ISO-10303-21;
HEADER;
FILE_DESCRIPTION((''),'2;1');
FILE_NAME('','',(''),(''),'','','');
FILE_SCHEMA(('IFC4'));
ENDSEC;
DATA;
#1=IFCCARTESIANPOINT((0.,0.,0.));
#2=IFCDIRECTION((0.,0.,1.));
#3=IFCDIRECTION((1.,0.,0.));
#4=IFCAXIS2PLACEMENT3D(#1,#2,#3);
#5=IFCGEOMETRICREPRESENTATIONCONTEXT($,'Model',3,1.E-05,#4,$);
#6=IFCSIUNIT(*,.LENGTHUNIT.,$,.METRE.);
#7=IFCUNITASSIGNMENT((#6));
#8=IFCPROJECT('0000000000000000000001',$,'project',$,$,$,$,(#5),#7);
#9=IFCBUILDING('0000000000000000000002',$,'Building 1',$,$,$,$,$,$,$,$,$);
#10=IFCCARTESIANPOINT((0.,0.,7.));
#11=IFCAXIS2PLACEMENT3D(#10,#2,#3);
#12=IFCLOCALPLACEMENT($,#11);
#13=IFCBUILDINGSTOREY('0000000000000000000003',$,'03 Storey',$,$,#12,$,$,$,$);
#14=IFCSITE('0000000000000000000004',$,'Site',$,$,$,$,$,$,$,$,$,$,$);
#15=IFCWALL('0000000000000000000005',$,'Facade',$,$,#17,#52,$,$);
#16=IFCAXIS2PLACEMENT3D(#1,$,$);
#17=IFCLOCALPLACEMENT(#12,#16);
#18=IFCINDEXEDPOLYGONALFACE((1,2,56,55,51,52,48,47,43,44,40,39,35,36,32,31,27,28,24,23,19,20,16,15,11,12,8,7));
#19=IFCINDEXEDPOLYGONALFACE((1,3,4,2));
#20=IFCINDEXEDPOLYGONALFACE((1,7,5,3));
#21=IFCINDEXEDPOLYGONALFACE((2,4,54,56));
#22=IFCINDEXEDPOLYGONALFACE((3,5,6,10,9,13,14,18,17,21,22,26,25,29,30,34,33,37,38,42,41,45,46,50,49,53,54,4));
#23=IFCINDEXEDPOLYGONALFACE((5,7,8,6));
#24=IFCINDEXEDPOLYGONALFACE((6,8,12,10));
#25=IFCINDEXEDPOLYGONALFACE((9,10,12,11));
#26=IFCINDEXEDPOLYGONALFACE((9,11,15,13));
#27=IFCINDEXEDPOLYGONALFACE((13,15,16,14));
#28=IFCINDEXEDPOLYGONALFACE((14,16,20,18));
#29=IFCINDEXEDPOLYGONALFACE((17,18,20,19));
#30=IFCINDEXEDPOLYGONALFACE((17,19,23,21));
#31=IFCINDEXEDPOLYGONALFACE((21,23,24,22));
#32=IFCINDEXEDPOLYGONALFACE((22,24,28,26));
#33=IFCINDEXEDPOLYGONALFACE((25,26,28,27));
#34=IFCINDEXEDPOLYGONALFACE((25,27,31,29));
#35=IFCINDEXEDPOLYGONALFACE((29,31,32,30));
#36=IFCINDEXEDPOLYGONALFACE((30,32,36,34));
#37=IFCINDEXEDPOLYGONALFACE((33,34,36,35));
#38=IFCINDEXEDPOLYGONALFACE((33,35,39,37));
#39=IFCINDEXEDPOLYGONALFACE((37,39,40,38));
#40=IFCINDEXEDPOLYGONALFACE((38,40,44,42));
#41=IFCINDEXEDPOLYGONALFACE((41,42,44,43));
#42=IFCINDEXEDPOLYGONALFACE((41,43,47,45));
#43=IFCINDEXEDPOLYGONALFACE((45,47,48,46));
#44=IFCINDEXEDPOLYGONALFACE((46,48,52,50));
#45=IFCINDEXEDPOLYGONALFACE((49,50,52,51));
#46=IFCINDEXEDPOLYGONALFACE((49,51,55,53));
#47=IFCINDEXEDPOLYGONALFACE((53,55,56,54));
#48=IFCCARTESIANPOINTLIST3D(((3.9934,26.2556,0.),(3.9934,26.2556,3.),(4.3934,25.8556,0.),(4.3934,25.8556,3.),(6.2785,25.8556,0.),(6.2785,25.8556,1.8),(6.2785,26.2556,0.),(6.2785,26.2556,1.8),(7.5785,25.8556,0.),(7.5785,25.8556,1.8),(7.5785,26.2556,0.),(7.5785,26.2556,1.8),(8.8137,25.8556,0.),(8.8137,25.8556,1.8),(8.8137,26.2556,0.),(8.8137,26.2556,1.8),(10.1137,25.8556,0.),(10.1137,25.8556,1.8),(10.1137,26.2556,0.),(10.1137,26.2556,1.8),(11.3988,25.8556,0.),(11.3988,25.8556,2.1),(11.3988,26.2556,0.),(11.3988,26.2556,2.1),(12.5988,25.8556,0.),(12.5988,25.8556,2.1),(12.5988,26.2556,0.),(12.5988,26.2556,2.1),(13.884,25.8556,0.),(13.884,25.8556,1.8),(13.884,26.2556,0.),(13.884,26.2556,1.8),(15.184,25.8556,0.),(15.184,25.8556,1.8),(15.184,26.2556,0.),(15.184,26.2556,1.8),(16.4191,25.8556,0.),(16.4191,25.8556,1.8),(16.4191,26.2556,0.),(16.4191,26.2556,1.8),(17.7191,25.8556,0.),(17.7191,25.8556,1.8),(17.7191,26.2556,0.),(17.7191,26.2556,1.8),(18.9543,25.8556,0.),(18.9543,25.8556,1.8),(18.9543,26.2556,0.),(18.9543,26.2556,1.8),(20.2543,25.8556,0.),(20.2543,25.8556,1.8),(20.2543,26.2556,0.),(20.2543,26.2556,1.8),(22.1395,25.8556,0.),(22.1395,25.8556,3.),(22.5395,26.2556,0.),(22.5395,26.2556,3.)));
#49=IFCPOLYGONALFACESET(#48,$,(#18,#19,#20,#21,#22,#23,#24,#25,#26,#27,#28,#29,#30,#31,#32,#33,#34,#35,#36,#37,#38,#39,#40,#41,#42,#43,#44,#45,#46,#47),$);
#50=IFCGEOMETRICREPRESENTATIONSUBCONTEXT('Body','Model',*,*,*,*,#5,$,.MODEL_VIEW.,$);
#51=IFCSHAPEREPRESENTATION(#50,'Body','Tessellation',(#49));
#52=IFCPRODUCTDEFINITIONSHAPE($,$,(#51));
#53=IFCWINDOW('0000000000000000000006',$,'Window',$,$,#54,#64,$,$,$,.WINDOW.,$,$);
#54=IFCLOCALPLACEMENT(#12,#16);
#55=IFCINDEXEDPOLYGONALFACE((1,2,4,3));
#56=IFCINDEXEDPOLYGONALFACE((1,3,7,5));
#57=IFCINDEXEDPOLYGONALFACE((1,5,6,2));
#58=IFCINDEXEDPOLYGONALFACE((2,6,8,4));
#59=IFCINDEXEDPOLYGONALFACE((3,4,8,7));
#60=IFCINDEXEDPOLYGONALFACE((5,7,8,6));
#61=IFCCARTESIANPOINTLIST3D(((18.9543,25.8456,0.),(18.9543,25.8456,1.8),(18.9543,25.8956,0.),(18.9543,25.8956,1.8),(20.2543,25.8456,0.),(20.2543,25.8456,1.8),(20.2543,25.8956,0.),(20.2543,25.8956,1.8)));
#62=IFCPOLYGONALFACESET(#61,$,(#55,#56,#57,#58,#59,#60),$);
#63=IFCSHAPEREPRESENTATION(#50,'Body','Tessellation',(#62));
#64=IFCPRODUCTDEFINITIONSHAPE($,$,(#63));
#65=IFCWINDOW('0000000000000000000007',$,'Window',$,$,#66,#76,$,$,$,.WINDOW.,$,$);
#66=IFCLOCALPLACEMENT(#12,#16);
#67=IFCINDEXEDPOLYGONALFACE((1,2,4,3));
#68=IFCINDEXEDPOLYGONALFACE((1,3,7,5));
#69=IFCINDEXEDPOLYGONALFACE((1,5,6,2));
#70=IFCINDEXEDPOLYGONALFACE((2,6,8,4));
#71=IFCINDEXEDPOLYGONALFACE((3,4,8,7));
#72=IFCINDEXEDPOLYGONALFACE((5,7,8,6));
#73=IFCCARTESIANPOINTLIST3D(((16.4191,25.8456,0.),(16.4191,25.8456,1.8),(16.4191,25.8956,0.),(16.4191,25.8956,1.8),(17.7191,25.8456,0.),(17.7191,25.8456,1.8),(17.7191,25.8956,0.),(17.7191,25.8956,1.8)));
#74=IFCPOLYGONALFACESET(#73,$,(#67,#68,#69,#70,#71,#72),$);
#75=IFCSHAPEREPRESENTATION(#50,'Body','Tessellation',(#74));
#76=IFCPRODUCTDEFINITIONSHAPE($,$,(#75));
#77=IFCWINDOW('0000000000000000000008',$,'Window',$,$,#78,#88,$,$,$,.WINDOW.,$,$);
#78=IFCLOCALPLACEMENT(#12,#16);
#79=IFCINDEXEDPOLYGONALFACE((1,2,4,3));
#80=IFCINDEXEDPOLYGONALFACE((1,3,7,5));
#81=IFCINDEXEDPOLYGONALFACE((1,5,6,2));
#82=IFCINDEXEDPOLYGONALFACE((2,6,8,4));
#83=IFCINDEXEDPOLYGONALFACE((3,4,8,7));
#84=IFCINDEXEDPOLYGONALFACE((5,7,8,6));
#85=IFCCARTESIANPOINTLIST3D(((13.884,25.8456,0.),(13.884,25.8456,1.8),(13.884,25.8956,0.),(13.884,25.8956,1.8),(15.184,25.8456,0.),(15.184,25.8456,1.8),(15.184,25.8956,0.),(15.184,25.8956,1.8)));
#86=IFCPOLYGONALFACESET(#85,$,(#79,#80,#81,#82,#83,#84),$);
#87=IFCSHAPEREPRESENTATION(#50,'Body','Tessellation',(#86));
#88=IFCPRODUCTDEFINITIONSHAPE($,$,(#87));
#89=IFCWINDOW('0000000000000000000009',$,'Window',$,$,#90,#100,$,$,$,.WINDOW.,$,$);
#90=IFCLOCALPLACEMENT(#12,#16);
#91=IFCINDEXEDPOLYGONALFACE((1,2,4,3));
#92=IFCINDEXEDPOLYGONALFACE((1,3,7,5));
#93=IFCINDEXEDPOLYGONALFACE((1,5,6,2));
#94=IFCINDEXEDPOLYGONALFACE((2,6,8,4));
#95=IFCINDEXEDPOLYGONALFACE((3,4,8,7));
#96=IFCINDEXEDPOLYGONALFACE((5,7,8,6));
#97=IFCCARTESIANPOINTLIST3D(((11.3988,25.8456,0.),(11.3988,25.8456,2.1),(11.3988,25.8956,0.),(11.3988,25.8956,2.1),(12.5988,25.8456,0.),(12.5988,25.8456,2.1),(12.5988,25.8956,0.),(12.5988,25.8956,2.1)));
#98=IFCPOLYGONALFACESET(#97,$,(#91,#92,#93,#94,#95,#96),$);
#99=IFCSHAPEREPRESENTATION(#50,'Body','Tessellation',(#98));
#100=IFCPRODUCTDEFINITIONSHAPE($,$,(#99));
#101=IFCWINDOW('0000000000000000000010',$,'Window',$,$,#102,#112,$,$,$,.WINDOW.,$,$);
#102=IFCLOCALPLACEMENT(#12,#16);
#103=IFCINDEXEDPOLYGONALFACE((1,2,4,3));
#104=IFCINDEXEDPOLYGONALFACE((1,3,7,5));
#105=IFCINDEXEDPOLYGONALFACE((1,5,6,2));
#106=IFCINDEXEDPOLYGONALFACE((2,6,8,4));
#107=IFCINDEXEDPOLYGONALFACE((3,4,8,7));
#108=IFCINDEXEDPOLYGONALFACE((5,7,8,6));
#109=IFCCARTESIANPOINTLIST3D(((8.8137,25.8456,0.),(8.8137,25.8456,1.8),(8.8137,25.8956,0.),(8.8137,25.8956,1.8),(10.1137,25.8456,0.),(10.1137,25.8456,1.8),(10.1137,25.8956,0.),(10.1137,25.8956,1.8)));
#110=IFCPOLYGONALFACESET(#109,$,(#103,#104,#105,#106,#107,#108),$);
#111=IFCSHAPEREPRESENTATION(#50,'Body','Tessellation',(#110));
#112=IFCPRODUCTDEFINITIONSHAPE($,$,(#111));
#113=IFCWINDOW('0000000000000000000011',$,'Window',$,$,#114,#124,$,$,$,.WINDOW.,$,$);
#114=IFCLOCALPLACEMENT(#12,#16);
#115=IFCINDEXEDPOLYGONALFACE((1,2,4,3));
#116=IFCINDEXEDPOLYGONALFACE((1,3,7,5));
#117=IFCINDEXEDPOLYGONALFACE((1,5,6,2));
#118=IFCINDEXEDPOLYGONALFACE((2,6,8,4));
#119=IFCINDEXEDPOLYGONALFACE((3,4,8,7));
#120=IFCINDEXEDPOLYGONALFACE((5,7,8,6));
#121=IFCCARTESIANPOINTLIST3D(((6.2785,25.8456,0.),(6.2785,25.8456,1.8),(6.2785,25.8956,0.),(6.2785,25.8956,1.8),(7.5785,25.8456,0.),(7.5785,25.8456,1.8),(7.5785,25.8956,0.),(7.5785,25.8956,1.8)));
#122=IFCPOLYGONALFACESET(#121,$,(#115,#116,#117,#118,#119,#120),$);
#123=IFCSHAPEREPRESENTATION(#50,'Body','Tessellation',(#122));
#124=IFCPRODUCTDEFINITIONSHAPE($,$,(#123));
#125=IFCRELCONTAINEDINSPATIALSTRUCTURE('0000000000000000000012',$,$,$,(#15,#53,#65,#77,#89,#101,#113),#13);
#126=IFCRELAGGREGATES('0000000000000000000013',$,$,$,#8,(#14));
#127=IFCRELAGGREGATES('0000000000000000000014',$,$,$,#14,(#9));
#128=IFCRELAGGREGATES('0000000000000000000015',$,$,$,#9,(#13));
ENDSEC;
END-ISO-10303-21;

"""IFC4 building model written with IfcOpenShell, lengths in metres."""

from ifc_helpers import new_model, si_unit, frame, origin_with_axes, place, context, subcontext, project, spatial, line, indexed_curve, outline, extrude, element, fill, save


model = new_model("IFC4")

# Units and contexts
model_context = context("Model", 3, precision=1e-05, world=origin_with_axes())
body_context = subcontext(model_context, "Body", "Model", "MODEL_VIEW")
ifc_project = project(units=[si_unit("LENGTHUNIT", "METRE")], contexts=[model_context])

# Site, building, storey
site = spatial("IfcSite", under=ifc_project, Name="Site")
building = spatial("IfcBuilding", under=site, Name="Building 1")
storey_placement = place(None, frame((0.0, 0.0, 7.0), z_axis=(0.0, 0.0, 1.0), x_axis=(1.0, 0.0, 0.0)))
storey = spatial("IfcBuildingStorey", under=building, at=storey_placement, Name="03 Storey")

# Wall, openings, windows
wall_1_placement = place(storey_placement, origin_with_axes())
wall_1 = element("IfcWall", 1, at=wall_1_placement, inside=storey, Name="Facade", context=body_context, shape_type="SweptSolid", body=[
    extrude(outline(indexed_curve([(22.1395, 25.8556), (4.3934, 25.8556), (3.9934, 26.2556), (22.5395, 26.2556)], segments=[line(1, 2), line(2, 3), line(3, 4)])), origin_with_axes(), (0.0, 0.0, 1.0), 3.0),
])
opening_1_placement = place(wall_1_placement, origin_with_axes())
opening_1 = element("IfcOpeningElement", 2, at=opening_1_placement, cuts=wall_1, context=body_context, shape_type="SweptSolid", body=[
    extrude(outline(indexed_curve([(20.2543, 26.2956), (20.2543, 25.7956), (18.9543, 25.7956), (18.9543, 26.2956)], segments=[line(1, 2), line(2, 3), line(3, 4)])), origin_with_axes(), (0.0, 0.0, 1.0), 1.8),
])
opening_2_placement = place(wall_1_placement, origin_with_axes())
opening_2 = element("IfcOpeningElement", 3, at=opening_2_placement, cuts=wall_1, context=body_context, shape_type="SweptSolid", body=[
    extrude(outline(indexed_curve([(17.7191, 26.2956), (17.7191, 25.7956), (16.4191, 25.7956), (16.4191, 26.2956)], segments=[line(1, 2), line(2, 3), line(3, 4)])), origin_with_axes(), (0.0, 0.0, 1.0), 1.8),
])
opening_3_placement = place(wall_1_placement, origin_with_axes())
opening_3 = element("IfcOpeningElement", 4, at=opening_3_placement, cuts=wall_1, context=body_context, shape_type="SweptSolid", body=[
    extrude(outline(indexed_curve([(15.184, 26.2956), (15.184, 25.7956), (13.884, 25.7956), (13.884, 26.2956)], segments=[line(1, 2), line(2, 3), line(3, 4)])), origin_with_axes(), (0.0, 0.0, 1.0), 1.8),
])
opening_4_placement = place(wall_1_placement, origin_with_axes())
opening_4 = element("IfcOpeningElement", 5, at=opening_4_placement, cuts=wall_1, context=body_context, shape_type="SweptSolid", body=[
    extrude(outline(indexed_curve([(12.5988, 26.2956), (12.5988, 25.7956), (11.3988, 25.7956), (11.3988, 26.2956)], segments=[line(1, 2), line(2, 3), line(3, 4)])), origin_with_axes(), (0.0, 0.0, 1.0), 2.1),
])
opening_5_placement = place(wall_1_placement, origin_with_axes())
opening_5 = element("IfcOpeningElement", 6, at=opening_5_placement, cuts=wall_1, context=body_context, shape_type="SweptSolid", body=[
    extrude(outline(indexed_curve([(10.1137, 26.2956), (10.1137, 25.7956), (8.8137, 25.7956), (8.8137, 26.2956)], segments=[line(1, 2), line(2, 3), line(3, 4)])), origin_with_axes(), (0.0, 0.0, 1.0), 1.8),
])
opening_6_placement = place(wall_1_placement, origin_with_axes())
opening_6 = element("IfcOpeningElement", 7, at=opening_6_placement, cuts=wall_1, context=body_context, shape_type="SweptSolid", body=[
    extrude(outline(indexed_curve([(7.5785, 26.2956), (7.5785, 25.7956), (6.2785, 25.7956), (6.2785, 26.2956)], segments=[line(1, 2), line(2, 3), line(3, 4)])), origin_with_axes(), (0.0, 0.0, 1.0), 1.8),
])
window_1_placement = place(storey_placement, origin_with_axes())
window_1 = element("IfcWindow", 8, at=window_1_placement, inside=storey, Name="Window", PredefinedType="WINDOW", context=body_context, shape_type="SweptSolid", body=[
    extrude(outline(indexed_curve([(20.2543, 25.8956), (20.2543, 25.8456), (18.9543, 25.8456), (18.9543, 25.8956)], segments=[line(1, 2), line(2, 3), line(3, 4)])), origin_with_axes(), (0.0, 0.0, 1.0), 1.8),
])
fill(opening_1, window_1)
window_2_placement = place(storey_placement, origin_with_axes())
window_2 = element("IfcWindow", 9, at=window_2_placement, inside=storey, Name="Window", PredefinedType="WINDOW", context=body_context, shape_type="SweptSolid", body=[
    extrude(outline(indexed_curve([(17.7191, 25.8956), (17.7191, 25.8456), (16.4191, 25.8456), (16.4191, 25.8956)], segments=[line(1, 2), line(2, 3), line(3, 4)])), origin_with_axes(), (0.0, 0.0, 1.0), 1.8),
])
fill(opening_2, window_2)
window_3_placement = place(storey_placement, origin_with_axes())
window_3 = element("IfcWindow", 10, at=window_3_placement, inside=storey, Name="Window", PredefinedType="WINDOW", context=body_context, shape_type="SweptSolid", body=[
    extrude(outline(indexed_curve([(15.184, 25.8956), (15.184, 25.8456), (13.884, 25.8456), (13.884, 25.8956)], segments=[line(1, 2), line(2, 3), line(3, 4)])), origin_with_axes(), (0.0, 0.0, 1.0), 1.8),
])
fill(opening_3, window_3)
window_4_placement = place(storey_placement, origin_with_axes())
window_4 = element("IfcWindow", 11, at=window_4_placement, inside=storey, Name="Window", PredefinedType="WINDOW", context=body_context, shape_type="SweptSolid", body=[
    extrude(outline(indexed_curve([(12.5988, 25.8956), (12.5988, 25.8456), (11.3988, 25.8456), (11.3988, 25.8956)], segments=[line(1, 2), line(2, 3), line(3, 4)])), origin_with_axes(), (0.0, 0.0, 1.0), 2.1),
])
fill(opening_4, window_4)
window_5_placement = place(storey_placement, origin_with_axes())
window_5 = element("IfcWindow", 12, at=window_5_placement, inside=storey, Name="Window", PredefinedType="WINDOW", context=body_context, shape_type="SweptSolid", body=[
    extrude(outline(indexed_curve([(10.1137, 25.8956), (10.1137, 25.8456), (8.8137, 25.8456), (8.8137, 25.8956)], segments=[line(1, 2), line(2, 3), line(3, 4)])), origin_with_axes(), (0.0, 0.0, 1.0), 1.8),
])
fill(opening_5, window_5)
window_6_placement = place(storey_placement, origin_with_axes())
window_6 = element("IfcWindow", 13, at=window_6_placement, inside=storey, Name="Window", PredefinedType="WINDOW", context=body_context, shape_type="SweptSolid", body=[
    extrude(outline(indexed_curve([(7.5785, 25.8956), (7.5785, 25.8456), (6.2785, 25.8456), (6.2785, 25.8956)], segments=[line(1, 2), line(2, 3), line(3, 4)])), origin_with_axes(), (0.0, 0.0, 1.0), 1.8),
])
fill(opening_6, window_6)

save(model, "model.ifc")
